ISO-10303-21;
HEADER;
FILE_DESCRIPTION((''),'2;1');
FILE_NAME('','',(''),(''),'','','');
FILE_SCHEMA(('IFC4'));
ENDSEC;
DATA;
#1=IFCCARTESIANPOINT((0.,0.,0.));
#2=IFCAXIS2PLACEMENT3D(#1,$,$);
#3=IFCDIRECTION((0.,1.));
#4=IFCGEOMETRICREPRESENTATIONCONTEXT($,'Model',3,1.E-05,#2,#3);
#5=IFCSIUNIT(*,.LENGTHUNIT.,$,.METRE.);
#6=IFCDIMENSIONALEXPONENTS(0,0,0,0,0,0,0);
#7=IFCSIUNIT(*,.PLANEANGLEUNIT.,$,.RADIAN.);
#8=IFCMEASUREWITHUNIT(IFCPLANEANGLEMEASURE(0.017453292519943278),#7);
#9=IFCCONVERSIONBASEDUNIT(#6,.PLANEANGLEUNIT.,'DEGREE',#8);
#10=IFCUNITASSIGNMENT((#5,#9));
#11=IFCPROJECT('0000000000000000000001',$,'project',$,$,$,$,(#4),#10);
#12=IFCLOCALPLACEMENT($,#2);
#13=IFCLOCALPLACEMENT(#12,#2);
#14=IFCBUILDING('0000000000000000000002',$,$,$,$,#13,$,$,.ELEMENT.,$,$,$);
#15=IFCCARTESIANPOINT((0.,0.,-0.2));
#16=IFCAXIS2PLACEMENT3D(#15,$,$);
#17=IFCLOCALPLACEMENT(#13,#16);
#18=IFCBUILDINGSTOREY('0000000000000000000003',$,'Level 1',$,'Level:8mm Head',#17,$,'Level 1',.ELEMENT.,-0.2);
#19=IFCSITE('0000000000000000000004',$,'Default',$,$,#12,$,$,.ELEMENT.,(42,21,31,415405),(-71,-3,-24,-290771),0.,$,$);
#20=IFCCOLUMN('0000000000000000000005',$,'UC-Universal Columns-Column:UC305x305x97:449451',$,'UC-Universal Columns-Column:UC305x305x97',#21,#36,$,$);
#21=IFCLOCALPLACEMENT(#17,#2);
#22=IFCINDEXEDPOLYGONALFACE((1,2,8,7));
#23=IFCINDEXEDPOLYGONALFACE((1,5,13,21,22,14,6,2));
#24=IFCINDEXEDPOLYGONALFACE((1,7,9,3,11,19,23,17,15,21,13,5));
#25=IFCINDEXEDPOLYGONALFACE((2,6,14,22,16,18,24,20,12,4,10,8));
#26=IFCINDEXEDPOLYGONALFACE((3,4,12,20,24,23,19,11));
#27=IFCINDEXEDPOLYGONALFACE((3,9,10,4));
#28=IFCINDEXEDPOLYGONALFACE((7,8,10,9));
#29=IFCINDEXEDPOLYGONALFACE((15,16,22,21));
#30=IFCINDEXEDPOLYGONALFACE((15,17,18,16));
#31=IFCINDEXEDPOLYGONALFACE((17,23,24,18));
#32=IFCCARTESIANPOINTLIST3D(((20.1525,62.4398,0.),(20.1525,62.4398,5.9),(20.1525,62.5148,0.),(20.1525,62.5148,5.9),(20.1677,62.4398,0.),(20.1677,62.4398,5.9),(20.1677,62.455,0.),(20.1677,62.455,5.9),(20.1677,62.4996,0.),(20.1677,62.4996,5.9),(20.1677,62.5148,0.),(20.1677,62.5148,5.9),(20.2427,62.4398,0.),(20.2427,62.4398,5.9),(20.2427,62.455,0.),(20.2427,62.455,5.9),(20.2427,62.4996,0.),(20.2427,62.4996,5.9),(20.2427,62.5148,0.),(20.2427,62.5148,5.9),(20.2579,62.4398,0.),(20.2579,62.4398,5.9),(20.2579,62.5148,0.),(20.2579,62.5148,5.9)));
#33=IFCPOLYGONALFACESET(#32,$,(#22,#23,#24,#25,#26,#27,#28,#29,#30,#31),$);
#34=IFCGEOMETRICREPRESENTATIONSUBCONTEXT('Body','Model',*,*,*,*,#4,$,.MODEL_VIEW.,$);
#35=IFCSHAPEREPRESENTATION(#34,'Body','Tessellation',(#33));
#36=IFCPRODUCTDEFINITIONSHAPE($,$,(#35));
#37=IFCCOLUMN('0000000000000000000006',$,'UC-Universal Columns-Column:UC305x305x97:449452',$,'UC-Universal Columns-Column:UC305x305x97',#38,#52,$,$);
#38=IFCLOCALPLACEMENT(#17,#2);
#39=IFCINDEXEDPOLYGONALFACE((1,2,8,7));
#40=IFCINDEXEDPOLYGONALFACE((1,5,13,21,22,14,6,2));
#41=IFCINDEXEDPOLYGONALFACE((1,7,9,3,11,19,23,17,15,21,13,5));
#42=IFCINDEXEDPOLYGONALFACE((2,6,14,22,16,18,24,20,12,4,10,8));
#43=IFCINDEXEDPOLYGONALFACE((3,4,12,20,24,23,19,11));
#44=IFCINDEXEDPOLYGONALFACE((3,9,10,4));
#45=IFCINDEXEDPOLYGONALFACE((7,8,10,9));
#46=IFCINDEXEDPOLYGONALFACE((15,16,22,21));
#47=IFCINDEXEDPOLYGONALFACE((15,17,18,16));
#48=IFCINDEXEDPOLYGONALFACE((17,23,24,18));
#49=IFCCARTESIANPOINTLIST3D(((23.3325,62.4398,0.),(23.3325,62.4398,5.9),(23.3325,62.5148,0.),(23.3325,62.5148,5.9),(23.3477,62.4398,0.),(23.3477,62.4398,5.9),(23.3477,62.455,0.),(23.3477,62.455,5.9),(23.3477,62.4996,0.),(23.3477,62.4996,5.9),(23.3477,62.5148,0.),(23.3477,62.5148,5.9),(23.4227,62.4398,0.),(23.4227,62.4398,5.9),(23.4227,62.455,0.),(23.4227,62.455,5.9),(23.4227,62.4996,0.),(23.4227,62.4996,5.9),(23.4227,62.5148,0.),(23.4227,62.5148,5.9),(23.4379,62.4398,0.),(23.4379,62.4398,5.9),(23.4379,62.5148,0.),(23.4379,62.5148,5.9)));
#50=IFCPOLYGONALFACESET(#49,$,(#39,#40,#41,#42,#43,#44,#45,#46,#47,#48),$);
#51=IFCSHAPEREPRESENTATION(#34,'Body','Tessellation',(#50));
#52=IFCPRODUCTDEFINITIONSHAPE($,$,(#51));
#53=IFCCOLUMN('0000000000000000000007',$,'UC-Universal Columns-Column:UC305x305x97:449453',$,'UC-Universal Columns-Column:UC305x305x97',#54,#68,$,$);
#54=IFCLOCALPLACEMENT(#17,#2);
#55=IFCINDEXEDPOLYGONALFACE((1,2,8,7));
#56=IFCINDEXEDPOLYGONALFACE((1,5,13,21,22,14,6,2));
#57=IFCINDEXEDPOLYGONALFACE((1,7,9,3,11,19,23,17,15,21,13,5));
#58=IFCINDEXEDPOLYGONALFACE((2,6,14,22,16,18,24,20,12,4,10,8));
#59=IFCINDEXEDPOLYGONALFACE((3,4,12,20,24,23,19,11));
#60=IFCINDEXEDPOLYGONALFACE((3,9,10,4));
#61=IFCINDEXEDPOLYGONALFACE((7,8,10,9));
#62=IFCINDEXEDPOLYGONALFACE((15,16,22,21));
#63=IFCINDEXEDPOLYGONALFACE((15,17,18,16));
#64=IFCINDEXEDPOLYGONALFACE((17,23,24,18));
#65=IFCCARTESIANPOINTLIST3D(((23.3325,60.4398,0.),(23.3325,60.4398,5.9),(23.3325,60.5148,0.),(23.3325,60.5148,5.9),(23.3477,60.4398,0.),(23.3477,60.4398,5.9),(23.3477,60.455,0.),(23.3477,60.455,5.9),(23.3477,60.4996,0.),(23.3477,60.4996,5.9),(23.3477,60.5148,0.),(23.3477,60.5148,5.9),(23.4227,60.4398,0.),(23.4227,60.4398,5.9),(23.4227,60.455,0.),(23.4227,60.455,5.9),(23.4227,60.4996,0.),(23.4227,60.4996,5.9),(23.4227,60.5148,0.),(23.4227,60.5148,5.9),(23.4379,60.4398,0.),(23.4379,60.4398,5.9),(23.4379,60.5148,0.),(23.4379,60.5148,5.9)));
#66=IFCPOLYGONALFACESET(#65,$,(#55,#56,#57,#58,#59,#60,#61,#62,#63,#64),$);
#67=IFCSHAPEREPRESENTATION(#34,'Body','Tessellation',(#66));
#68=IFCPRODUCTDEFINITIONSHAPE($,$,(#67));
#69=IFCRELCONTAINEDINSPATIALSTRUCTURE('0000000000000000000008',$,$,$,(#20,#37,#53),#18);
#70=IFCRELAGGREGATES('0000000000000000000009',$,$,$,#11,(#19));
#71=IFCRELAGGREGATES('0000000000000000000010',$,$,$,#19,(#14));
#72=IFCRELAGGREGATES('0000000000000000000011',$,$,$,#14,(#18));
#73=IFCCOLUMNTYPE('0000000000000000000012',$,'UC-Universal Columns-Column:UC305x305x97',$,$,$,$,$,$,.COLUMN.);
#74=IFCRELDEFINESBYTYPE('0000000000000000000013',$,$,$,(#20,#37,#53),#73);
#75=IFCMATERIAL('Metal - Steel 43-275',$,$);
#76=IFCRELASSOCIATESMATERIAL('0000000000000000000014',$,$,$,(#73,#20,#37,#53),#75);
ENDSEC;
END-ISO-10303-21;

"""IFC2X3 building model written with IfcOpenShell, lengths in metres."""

from ifc_helpers import new_model, entity, si_unit, converted_unit, direction, frame, frame_2d, origin, place, context, subcontext, project, spatial, polyline, circle_curve, parameter, trimmed, segment, composite_curve, outline, extrude, source, transform, mapped, material, type_object, type_shapes, element, save


model = new_model("IFC2X3")

# Units and contexts
model_context = context("Model", 3, precision=1e-05, world=origin(), true_north=direction((0.0, 1.0)))
body_context = subcontext(model_context, "Body", "Model", "MODEL_VIEW")
ifc_project = project(units=[si_unit("LENGTHUNIT", "METRE"), converted_unit("PLANEANGLEUNIT", "DEGREE", entity("IfcPlaneAngleMeasure", 0.017453292519943278), si_unit("PLANEANGLEUNIT", "RADIAN"), dimensions=[0, 0, 0, 0, 0, 0, 0])], contexts=[model_context])

# Site, building, storey
site_placement = place(None, origin())
site = spatial("IfcSite", under=ifc_project, at=site_placement, Name="Default", CompositionType="ELEMENT", RefLatitude=(42, 21, 31, 415405), RefLongitude=(-71, -3, -24, -290771), RefElevation=0.0)
building_placement = place(site_placement, origin())
building = spatial("IfcBuilding", under=site, at=building_placement, CompositionType="ELEMENT")
storey_placement = place(building_placement, frame((0.0, 0.0, -0.2)))
storey = spatial("IfcBuildingStorey", under=building, at=storey_placement, Name="Level 1", ObjectType="Level:8mm Head", LongName="Level 1", CompositionType="ELEMENT", Elevation=-0.2)

# Columns
ifc_material = material(Name="Metal - Steel 43-275")
column_type = type_object("IfcColumnType", Name="UC-Universal Columns-Column:UC305x305x97", PredefinedType="COLUMN", material=ifc_material)
shared_shape = source(origin(), body_context, "Body", "SweptSolid", [
    extrude(outline(composite_curve([segment(polyline([(-0.0375, -0.0375), (0.0375, -0.0375)]), True, "CONTINUOUS"), segment(polyline([(0.0375, -0.0375), (0.0527, -0.0375)]), True, "CONTINUOUS"), segment(trimmed(circle_curve(frame_2d((0.0527, -0.0223), x_axis=(-1.0, 0.0)), 0.0152), [parameter(0.0)], [parameter(90.0)], True, "PARAMETER"), False, "CONTINUOUS"), segment(polyline([(0.0375, -0.0223), (0.0375, 0.0223)]), True, "CONTINUOUS"), segment(trimmed(circle_curve(frame_2d((0.0527, 0.0223), x_axis=(-1.0, 0.0)), 0.0152), [parameter(270.0)], [parameter(0.0)], True, "PARAMETER"), False, "CONTINUOUS"), segment(polyline([(0.0527, 0.0375), (0.0375, 0.0375)]), True, "CONTINUOUS"), segment(polyline([(0.0375, 0.0375), (-0.0375, 0.0375)]), True, "CONTINUOUS"), segment(polyline([(-0.0375, 0.0375), (-0.0527, 0.0375)]), True, "CONTINUOUS"), segment(trimmed(circle_curve(frame_2d((-0.0527, 0.0223), x_axis=(-1.0, 0.0)), 0.0152), [parameter(180.0)], [parameter(270.0)], True, "PARAMETER"), False, "CONTINUOUS"), segment(polyline([(-0.0375, 0.0223), (-0.0375, -0.0223)]), True, "CONTINUOUS"), segment(trimmed(circle_curve(frame_2d((-0.0527, -0.0223), x_axis=(-1.0, 0.0)), 0.0152), [parameter(90.0)], [parameter(180.0)], True, "PARAMETER"), False, "CONTINUOUS"), segment(polyline([(-0.0527, -0.0375), (-0.0375, -0.0375)]), True, "CONTINUOUS")], self_intersect=False)), frame((0.0, 0.0, -0.2), z_axis=(0.0, 0.0, 1.0), x_axis=(-1.0, 0.0, 0.0)), (0.0, 0.0, 1.0), 5.9),
])
type_shapes(column_type, [shared_shape])
for number, where, z_axis, x_axis, name in (
    (1, (20.2052, 62.4773, 0.2), (0.0, 0.0, 1.0), (-1.0, 0.0, 0.0), "UC-Universal Columns-Column:UC305x305x97:449451"),
    (2, (23.3852, 62.4773, 0.2), (0.0, 0.0, 1.0), (-1.0, 0.0, 0.0), "UC-Universal Columns-Column:UC305x305x97:449452"),
    (3, (23.3852, 60.4773, 0.2), (0.0, 0.0, 1.0), (-1.0, 0.0, 0.0), "UC-Universal Columns-Column:UC305x305x97:449453"),
):
    element("IfcColumn", number, at=place(storey_placement, frame(where, z_axis=z_axis, x_axis=x_axis)), inside=storey, type_object=column_type, material=ifc_material, Name=name, ObjectType="UC-Universal Columns-Column:UC305x305x97", context=body_context, shape_type="MappedRepresentation", body=[
        mapped(shared_shape, transform((0.0, 0.0, 0.0), scale=1.0)),
    ])

save(model, "model.ifc")
